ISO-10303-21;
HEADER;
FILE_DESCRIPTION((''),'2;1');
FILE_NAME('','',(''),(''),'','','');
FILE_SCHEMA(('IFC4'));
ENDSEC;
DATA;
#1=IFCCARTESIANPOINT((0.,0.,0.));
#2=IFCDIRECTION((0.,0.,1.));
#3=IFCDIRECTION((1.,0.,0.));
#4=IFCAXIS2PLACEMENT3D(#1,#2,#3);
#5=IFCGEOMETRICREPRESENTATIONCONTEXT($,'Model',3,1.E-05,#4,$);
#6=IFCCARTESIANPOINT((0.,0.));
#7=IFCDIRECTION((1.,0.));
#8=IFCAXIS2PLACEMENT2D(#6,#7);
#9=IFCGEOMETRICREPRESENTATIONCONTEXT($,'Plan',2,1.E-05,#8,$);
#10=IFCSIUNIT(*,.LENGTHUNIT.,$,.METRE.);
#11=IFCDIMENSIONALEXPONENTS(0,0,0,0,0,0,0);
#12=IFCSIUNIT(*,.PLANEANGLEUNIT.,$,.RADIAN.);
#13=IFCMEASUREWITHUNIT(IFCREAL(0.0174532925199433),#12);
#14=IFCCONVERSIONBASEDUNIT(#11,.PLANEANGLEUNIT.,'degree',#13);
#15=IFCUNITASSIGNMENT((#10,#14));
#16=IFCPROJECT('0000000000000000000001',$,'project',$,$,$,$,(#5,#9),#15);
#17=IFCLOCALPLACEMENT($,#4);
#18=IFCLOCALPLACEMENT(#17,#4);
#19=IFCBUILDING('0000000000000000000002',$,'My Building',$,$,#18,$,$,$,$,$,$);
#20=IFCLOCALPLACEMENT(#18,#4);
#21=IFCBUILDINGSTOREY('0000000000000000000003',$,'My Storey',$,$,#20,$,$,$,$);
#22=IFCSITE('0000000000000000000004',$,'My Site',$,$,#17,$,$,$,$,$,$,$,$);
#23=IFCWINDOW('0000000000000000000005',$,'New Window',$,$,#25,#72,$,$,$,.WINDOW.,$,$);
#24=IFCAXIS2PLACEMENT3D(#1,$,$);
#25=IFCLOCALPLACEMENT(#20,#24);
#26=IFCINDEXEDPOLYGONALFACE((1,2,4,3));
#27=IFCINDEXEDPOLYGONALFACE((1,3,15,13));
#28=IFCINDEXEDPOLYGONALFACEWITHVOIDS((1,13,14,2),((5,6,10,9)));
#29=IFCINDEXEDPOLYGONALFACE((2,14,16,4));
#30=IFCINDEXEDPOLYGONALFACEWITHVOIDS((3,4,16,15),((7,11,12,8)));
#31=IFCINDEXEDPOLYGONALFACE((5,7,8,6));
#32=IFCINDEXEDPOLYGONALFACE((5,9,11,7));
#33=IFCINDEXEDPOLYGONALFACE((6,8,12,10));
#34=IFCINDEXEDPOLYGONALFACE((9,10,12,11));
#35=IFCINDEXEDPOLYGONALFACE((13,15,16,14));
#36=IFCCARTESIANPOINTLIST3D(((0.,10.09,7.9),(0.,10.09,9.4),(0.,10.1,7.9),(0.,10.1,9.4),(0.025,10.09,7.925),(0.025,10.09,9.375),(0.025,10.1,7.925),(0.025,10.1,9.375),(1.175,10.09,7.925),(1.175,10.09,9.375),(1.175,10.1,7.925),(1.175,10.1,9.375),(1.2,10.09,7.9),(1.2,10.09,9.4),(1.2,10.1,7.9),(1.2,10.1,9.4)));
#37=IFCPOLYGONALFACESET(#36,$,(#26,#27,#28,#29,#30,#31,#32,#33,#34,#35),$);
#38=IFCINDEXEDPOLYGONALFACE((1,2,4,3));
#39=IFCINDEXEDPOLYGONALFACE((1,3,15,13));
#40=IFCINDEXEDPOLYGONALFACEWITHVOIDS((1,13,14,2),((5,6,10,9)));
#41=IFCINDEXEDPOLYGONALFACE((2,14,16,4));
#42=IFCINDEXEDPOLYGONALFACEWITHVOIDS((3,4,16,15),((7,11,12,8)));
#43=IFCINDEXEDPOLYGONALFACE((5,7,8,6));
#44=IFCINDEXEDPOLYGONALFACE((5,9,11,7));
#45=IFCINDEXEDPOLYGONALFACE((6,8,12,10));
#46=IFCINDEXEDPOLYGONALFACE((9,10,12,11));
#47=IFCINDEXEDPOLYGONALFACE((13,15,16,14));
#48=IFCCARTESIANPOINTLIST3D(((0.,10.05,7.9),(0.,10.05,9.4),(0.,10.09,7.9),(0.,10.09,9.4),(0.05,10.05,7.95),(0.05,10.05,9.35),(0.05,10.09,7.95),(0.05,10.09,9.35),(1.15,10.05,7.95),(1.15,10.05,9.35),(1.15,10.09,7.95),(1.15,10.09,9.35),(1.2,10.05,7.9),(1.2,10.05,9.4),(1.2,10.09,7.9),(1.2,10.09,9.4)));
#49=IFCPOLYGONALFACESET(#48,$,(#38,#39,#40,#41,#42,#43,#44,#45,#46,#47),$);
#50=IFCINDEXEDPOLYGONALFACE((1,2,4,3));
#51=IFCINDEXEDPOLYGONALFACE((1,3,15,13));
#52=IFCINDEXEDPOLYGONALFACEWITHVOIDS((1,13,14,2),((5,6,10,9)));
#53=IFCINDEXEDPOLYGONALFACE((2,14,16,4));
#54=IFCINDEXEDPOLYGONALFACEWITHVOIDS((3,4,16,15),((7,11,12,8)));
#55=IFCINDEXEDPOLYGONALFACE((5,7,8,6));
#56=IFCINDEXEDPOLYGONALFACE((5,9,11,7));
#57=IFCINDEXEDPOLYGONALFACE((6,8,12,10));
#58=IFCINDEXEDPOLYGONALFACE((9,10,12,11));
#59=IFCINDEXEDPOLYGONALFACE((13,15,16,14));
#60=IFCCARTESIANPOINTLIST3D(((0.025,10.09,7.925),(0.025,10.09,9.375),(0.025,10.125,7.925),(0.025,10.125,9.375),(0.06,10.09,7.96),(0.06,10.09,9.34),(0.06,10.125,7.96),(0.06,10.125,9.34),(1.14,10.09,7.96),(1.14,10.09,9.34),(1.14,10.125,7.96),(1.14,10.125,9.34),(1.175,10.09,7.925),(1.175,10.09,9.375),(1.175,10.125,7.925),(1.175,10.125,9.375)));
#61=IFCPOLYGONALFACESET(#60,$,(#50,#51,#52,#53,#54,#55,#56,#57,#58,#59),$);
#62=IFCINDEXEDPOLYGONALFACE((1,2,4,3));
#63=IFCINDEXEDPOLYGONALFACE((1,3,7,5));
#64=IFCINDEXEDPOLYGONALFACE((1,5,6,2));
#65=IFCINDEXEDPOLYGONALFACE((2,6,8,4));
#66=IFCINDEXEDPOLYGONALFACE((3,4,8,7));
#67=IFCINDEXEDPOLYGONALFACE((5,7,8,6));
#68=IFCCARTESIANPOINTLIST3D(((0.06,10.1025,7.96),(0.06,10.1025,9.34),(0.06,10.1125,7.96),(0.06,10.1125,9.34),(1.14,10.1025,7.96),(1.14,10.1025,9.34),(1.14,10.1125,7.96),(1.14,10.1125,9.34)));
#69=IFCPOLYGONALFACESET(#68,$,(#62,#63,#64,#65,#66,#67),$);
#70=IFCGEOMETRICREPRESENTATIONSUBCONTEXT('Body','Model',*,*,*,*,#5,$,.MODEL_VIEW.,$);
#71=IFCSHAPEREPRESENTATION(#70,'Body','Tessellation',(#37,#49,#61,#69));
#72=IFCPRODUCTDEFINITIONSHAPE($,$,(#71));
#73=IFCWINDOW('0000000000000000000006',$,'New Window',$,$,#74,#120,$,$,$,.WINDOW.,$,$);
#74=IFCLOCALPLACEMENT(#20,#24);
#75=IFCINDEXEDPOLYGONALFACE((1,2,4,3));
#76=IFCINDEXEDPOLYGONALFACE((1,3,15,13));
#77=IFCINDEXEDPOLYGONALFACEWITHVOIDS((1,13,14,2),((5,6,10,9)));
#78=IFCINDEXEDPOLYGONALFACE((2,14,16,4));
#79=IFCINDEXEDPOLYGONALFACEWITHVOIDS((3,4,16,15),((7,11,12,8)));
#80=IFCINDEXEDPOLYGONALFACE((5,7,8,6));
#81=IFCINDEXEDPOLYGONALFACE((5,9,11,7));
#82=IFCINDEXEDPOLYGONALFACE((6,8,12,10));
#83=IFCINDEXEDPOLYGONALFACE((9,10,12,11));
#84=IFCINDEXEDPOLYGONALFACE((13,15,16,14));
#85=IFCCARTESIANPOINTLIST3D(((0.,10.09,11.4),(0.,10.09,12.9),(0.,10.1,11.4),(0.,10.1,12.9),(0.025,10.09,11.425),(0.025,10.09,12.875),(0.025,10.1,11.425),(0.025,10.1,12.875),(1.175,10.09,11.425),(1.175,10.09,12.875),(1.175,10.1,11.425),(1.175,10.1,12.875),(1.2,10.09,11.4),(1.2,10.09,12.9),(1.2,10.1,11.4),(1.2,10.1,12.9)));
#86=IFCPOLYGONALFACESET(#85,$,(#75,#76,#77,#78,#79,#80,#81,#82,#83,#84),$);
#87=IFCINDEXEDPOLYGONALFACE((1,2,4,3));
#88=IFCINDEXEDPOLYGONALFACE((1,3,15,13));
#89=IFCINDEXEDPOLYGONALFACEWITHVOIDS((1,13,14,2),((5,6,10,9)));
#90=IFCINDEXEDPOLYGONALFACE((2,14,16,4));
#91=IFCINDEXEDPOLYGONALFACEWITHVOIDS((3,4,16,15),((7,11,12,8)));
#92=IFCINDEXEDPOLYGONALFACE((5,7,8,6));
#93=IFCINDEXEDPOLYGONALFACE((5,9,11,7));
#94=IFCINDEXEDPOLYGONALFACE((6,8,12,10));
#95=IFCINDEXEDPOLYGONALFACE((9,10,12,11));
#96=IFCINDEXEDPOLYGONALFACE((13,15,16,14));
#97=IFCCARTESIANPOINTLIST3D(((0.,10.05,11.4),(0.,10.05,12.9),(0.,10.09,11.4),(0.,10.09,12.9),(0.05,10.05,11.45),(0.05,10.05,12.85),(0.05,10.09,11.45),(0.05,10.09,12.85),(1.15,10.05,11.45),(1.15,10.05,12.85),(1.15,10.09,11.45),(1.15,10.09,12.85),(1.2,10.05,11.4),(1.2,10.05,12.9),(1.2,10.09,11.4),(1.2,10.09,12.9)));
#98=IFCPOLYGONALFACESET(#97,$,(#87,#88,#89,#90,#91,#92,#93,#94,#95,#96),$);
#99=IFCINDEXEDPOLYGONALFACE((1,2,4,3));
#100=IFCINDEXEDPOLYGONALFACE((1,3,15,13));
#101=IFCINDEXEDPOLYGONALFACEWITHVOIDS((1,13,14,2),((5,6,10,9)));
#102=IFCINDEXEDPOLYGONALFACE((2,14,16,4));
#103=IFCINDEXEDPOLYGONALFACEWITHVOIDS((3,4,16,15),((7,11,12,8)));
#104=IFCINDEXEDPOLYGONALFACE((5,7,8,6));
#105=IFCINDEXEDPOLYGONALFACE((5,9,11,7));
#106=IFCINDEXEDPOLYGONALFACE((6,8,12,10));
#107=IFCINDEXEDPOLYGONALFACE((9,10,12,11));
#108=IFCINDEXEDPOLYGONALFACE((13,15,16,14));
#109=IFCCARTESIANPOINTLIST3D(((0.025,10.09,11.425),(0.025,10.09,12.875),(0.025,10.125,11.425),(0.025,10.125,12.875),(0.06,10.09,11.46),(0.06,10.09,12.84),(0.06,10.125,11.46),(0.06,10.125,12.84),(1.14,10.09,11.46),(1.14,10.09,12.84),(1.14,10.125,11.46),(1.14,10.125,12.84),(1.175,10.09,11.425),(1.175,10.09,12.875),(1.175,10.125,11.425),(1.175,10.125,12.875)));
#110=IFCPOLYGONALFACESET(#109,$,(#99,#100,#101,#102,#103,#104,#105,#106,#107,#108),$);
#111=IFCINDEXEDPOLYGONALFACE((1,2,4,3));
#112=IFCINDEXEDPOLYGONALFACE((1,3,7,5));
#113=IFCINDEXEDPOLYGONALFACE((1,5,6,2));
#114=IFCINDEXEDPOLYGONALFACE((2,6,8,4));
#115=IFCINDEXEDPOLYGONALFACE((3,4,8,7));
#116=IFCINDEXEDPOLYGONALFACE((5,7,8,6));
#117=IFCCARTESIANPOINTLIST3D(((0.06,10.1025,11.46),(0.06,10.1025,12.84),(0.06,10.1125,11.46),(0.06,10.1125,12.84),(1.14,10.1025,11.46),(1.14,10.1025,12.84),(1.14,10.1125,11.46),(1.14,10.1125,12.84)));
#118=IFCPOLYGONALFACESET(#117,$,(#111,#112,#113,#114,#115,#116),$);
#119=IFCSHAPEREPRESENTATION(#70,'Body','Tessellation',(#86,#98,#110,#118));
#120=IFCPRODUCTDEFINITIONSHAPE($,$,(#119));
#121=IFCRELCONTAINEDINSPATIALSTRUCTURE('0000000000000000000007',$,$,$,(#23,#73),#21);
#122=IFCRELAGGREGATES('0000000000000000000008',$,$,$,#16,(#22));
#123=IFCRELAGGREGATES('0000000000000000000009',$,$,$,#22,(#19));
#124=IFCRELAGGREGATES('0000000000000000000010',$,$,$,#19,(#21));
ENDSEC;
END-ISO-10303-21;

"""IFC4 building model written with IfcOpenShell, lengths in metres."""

from ifc_helpers import new_model, entity, si_unit, converted_unit, frame, origin_with_axes, origin_2d_with_axis, place, context, subcontext, project, spatial, line, indexed_curve, outline, extrude, element, save


model = new_model("IFC4")

# Units and contexts
model_context = context("Model", 3, precision=1e-05, world=origin_with_axes())
plan_context = context("Plan", 2, precision=1e-05, world=origin_2d_with_axis())
body_context = subcontext(model_context, "Body", "Model", "MODEL_VIEW")
ifc_project = project(units=[si_unit("LENGTHUNIT", "METRE"), converted_unit("PLANEANGLEUNIT", "degree", entity("IfcReal", 0.0174532925199433), si_unit("PLANEANGLEUNIT", "RADIAN"), dimensions=[0, 0, 0, 0, 0, 0, 0])], contexts=[model_context, plan_context])

# Site, building, storey
site_placement = place(None, origin_with_axes())
site = spatial("IfcSite", under=ifc_project, at=site_placement, Name="My Site")
building_placement = place(site_placement, origin_with_axes())
building = spatial("IfcBuilding", under=site, at=building_placement, Name="My Building")
storey_placement = place(building_placement, origin_with_axes())
storey = spatial("IfcBuildingStorey", under=building, at=storey_placement, Name="My Storey")

# Windows
for number, where, z_axis, x_axis, name in (
    (1, (0.0, 10.0, 7.9), (0.0, 0.0, 1.0), (1.0, 0.0, 0.0), "New Window"),
    (2, (0.0, 10.0, 11.4), (0.0, 0.0, 1.0), (1.0, 0.0, 0.0), "New Window"),
):
    element("IfcWindow", number, at=place(storey_placement, frame(where, z_axis=z_axis, x_axis=x_axis)), inside=storey, Name=name, PredefinedType="WINDOW", context=body_context, shape_type="SweptSolid", body=[
        extrude(outline(indexed_curve([(0.0, 0.0), (1.2, 0.0), (1.2, 1.5), (0.0, 1.5)], segments=[line(1, 2, 3, 4, 1)]), holes=[indexed_curve([(0.025, 0.025), (1.175, 0.025), (1.175, 1.475), (0.025, 1.475)], segments=[line(1, 2, 3, 4, 1)])]), frame((0.0, 0.09, 0.0), z_axis=(0.0, -1.0, 0.0), x_axis=(1.0, 0.0, 0.0)), (0.0, 0.0, -1.0), 0.01),
        extrude(outline(indexed_curve([(0.0, 0.0), (1.2, 0.0), (1.2, 1.5), (0.0, 1.5)], segments=[line(1, 2, 3, 4, 1)]), holes=[indexed_curve([(0.05, 0.05), (1.15, 0.05), (1.15, 1.45), (0.05, 1.45)], segments=[line(1, 2, 3, 4, 1)])]), frame((0.0, 0.05, 0.0), z_axis=(0.0, -1.0, 0.0), x_axis=(1.0, 0.0, 0.0)), (0.0, 0.0, -1.0), 0.04),
        extrude(outline(indexed_curve([(0.0, 0.0), (1.15, 0.0), (1.15, 1.45), (0.0, 1.45)], segments=[line(1, 2, 3, 4, 1)]), holes=[indexed_curve([(0.035, 0.035), (1.115, 0.035), (1.115, 1.415), (0.035, 1.415)], segments=[line(1, 2, 3, 4, 1)])]), frame((0.025, 0.09, 0.025), z_axis=(0.0, -1.0, 0.0), x_axis=(1.0, 0.0, 0.0)), (0.0, 0.0, -1.0), 0.035),
        extrude(outline(indexed_curve([(0.035, 0.035), (1.115, 0.035), (1.115, 1.415), (0.035, 1.415)], segments=[line(1, 2, 3, 4, 1)])), frame((0.025, 0.1025, 0.025), z_axis=(0.0, -1.0, 0.0), x_axis=(1.0, 0.0, 0.0)), (0.0, 0.0, -1.0), 0.01),
    ])

save(model, "model.ifc")
